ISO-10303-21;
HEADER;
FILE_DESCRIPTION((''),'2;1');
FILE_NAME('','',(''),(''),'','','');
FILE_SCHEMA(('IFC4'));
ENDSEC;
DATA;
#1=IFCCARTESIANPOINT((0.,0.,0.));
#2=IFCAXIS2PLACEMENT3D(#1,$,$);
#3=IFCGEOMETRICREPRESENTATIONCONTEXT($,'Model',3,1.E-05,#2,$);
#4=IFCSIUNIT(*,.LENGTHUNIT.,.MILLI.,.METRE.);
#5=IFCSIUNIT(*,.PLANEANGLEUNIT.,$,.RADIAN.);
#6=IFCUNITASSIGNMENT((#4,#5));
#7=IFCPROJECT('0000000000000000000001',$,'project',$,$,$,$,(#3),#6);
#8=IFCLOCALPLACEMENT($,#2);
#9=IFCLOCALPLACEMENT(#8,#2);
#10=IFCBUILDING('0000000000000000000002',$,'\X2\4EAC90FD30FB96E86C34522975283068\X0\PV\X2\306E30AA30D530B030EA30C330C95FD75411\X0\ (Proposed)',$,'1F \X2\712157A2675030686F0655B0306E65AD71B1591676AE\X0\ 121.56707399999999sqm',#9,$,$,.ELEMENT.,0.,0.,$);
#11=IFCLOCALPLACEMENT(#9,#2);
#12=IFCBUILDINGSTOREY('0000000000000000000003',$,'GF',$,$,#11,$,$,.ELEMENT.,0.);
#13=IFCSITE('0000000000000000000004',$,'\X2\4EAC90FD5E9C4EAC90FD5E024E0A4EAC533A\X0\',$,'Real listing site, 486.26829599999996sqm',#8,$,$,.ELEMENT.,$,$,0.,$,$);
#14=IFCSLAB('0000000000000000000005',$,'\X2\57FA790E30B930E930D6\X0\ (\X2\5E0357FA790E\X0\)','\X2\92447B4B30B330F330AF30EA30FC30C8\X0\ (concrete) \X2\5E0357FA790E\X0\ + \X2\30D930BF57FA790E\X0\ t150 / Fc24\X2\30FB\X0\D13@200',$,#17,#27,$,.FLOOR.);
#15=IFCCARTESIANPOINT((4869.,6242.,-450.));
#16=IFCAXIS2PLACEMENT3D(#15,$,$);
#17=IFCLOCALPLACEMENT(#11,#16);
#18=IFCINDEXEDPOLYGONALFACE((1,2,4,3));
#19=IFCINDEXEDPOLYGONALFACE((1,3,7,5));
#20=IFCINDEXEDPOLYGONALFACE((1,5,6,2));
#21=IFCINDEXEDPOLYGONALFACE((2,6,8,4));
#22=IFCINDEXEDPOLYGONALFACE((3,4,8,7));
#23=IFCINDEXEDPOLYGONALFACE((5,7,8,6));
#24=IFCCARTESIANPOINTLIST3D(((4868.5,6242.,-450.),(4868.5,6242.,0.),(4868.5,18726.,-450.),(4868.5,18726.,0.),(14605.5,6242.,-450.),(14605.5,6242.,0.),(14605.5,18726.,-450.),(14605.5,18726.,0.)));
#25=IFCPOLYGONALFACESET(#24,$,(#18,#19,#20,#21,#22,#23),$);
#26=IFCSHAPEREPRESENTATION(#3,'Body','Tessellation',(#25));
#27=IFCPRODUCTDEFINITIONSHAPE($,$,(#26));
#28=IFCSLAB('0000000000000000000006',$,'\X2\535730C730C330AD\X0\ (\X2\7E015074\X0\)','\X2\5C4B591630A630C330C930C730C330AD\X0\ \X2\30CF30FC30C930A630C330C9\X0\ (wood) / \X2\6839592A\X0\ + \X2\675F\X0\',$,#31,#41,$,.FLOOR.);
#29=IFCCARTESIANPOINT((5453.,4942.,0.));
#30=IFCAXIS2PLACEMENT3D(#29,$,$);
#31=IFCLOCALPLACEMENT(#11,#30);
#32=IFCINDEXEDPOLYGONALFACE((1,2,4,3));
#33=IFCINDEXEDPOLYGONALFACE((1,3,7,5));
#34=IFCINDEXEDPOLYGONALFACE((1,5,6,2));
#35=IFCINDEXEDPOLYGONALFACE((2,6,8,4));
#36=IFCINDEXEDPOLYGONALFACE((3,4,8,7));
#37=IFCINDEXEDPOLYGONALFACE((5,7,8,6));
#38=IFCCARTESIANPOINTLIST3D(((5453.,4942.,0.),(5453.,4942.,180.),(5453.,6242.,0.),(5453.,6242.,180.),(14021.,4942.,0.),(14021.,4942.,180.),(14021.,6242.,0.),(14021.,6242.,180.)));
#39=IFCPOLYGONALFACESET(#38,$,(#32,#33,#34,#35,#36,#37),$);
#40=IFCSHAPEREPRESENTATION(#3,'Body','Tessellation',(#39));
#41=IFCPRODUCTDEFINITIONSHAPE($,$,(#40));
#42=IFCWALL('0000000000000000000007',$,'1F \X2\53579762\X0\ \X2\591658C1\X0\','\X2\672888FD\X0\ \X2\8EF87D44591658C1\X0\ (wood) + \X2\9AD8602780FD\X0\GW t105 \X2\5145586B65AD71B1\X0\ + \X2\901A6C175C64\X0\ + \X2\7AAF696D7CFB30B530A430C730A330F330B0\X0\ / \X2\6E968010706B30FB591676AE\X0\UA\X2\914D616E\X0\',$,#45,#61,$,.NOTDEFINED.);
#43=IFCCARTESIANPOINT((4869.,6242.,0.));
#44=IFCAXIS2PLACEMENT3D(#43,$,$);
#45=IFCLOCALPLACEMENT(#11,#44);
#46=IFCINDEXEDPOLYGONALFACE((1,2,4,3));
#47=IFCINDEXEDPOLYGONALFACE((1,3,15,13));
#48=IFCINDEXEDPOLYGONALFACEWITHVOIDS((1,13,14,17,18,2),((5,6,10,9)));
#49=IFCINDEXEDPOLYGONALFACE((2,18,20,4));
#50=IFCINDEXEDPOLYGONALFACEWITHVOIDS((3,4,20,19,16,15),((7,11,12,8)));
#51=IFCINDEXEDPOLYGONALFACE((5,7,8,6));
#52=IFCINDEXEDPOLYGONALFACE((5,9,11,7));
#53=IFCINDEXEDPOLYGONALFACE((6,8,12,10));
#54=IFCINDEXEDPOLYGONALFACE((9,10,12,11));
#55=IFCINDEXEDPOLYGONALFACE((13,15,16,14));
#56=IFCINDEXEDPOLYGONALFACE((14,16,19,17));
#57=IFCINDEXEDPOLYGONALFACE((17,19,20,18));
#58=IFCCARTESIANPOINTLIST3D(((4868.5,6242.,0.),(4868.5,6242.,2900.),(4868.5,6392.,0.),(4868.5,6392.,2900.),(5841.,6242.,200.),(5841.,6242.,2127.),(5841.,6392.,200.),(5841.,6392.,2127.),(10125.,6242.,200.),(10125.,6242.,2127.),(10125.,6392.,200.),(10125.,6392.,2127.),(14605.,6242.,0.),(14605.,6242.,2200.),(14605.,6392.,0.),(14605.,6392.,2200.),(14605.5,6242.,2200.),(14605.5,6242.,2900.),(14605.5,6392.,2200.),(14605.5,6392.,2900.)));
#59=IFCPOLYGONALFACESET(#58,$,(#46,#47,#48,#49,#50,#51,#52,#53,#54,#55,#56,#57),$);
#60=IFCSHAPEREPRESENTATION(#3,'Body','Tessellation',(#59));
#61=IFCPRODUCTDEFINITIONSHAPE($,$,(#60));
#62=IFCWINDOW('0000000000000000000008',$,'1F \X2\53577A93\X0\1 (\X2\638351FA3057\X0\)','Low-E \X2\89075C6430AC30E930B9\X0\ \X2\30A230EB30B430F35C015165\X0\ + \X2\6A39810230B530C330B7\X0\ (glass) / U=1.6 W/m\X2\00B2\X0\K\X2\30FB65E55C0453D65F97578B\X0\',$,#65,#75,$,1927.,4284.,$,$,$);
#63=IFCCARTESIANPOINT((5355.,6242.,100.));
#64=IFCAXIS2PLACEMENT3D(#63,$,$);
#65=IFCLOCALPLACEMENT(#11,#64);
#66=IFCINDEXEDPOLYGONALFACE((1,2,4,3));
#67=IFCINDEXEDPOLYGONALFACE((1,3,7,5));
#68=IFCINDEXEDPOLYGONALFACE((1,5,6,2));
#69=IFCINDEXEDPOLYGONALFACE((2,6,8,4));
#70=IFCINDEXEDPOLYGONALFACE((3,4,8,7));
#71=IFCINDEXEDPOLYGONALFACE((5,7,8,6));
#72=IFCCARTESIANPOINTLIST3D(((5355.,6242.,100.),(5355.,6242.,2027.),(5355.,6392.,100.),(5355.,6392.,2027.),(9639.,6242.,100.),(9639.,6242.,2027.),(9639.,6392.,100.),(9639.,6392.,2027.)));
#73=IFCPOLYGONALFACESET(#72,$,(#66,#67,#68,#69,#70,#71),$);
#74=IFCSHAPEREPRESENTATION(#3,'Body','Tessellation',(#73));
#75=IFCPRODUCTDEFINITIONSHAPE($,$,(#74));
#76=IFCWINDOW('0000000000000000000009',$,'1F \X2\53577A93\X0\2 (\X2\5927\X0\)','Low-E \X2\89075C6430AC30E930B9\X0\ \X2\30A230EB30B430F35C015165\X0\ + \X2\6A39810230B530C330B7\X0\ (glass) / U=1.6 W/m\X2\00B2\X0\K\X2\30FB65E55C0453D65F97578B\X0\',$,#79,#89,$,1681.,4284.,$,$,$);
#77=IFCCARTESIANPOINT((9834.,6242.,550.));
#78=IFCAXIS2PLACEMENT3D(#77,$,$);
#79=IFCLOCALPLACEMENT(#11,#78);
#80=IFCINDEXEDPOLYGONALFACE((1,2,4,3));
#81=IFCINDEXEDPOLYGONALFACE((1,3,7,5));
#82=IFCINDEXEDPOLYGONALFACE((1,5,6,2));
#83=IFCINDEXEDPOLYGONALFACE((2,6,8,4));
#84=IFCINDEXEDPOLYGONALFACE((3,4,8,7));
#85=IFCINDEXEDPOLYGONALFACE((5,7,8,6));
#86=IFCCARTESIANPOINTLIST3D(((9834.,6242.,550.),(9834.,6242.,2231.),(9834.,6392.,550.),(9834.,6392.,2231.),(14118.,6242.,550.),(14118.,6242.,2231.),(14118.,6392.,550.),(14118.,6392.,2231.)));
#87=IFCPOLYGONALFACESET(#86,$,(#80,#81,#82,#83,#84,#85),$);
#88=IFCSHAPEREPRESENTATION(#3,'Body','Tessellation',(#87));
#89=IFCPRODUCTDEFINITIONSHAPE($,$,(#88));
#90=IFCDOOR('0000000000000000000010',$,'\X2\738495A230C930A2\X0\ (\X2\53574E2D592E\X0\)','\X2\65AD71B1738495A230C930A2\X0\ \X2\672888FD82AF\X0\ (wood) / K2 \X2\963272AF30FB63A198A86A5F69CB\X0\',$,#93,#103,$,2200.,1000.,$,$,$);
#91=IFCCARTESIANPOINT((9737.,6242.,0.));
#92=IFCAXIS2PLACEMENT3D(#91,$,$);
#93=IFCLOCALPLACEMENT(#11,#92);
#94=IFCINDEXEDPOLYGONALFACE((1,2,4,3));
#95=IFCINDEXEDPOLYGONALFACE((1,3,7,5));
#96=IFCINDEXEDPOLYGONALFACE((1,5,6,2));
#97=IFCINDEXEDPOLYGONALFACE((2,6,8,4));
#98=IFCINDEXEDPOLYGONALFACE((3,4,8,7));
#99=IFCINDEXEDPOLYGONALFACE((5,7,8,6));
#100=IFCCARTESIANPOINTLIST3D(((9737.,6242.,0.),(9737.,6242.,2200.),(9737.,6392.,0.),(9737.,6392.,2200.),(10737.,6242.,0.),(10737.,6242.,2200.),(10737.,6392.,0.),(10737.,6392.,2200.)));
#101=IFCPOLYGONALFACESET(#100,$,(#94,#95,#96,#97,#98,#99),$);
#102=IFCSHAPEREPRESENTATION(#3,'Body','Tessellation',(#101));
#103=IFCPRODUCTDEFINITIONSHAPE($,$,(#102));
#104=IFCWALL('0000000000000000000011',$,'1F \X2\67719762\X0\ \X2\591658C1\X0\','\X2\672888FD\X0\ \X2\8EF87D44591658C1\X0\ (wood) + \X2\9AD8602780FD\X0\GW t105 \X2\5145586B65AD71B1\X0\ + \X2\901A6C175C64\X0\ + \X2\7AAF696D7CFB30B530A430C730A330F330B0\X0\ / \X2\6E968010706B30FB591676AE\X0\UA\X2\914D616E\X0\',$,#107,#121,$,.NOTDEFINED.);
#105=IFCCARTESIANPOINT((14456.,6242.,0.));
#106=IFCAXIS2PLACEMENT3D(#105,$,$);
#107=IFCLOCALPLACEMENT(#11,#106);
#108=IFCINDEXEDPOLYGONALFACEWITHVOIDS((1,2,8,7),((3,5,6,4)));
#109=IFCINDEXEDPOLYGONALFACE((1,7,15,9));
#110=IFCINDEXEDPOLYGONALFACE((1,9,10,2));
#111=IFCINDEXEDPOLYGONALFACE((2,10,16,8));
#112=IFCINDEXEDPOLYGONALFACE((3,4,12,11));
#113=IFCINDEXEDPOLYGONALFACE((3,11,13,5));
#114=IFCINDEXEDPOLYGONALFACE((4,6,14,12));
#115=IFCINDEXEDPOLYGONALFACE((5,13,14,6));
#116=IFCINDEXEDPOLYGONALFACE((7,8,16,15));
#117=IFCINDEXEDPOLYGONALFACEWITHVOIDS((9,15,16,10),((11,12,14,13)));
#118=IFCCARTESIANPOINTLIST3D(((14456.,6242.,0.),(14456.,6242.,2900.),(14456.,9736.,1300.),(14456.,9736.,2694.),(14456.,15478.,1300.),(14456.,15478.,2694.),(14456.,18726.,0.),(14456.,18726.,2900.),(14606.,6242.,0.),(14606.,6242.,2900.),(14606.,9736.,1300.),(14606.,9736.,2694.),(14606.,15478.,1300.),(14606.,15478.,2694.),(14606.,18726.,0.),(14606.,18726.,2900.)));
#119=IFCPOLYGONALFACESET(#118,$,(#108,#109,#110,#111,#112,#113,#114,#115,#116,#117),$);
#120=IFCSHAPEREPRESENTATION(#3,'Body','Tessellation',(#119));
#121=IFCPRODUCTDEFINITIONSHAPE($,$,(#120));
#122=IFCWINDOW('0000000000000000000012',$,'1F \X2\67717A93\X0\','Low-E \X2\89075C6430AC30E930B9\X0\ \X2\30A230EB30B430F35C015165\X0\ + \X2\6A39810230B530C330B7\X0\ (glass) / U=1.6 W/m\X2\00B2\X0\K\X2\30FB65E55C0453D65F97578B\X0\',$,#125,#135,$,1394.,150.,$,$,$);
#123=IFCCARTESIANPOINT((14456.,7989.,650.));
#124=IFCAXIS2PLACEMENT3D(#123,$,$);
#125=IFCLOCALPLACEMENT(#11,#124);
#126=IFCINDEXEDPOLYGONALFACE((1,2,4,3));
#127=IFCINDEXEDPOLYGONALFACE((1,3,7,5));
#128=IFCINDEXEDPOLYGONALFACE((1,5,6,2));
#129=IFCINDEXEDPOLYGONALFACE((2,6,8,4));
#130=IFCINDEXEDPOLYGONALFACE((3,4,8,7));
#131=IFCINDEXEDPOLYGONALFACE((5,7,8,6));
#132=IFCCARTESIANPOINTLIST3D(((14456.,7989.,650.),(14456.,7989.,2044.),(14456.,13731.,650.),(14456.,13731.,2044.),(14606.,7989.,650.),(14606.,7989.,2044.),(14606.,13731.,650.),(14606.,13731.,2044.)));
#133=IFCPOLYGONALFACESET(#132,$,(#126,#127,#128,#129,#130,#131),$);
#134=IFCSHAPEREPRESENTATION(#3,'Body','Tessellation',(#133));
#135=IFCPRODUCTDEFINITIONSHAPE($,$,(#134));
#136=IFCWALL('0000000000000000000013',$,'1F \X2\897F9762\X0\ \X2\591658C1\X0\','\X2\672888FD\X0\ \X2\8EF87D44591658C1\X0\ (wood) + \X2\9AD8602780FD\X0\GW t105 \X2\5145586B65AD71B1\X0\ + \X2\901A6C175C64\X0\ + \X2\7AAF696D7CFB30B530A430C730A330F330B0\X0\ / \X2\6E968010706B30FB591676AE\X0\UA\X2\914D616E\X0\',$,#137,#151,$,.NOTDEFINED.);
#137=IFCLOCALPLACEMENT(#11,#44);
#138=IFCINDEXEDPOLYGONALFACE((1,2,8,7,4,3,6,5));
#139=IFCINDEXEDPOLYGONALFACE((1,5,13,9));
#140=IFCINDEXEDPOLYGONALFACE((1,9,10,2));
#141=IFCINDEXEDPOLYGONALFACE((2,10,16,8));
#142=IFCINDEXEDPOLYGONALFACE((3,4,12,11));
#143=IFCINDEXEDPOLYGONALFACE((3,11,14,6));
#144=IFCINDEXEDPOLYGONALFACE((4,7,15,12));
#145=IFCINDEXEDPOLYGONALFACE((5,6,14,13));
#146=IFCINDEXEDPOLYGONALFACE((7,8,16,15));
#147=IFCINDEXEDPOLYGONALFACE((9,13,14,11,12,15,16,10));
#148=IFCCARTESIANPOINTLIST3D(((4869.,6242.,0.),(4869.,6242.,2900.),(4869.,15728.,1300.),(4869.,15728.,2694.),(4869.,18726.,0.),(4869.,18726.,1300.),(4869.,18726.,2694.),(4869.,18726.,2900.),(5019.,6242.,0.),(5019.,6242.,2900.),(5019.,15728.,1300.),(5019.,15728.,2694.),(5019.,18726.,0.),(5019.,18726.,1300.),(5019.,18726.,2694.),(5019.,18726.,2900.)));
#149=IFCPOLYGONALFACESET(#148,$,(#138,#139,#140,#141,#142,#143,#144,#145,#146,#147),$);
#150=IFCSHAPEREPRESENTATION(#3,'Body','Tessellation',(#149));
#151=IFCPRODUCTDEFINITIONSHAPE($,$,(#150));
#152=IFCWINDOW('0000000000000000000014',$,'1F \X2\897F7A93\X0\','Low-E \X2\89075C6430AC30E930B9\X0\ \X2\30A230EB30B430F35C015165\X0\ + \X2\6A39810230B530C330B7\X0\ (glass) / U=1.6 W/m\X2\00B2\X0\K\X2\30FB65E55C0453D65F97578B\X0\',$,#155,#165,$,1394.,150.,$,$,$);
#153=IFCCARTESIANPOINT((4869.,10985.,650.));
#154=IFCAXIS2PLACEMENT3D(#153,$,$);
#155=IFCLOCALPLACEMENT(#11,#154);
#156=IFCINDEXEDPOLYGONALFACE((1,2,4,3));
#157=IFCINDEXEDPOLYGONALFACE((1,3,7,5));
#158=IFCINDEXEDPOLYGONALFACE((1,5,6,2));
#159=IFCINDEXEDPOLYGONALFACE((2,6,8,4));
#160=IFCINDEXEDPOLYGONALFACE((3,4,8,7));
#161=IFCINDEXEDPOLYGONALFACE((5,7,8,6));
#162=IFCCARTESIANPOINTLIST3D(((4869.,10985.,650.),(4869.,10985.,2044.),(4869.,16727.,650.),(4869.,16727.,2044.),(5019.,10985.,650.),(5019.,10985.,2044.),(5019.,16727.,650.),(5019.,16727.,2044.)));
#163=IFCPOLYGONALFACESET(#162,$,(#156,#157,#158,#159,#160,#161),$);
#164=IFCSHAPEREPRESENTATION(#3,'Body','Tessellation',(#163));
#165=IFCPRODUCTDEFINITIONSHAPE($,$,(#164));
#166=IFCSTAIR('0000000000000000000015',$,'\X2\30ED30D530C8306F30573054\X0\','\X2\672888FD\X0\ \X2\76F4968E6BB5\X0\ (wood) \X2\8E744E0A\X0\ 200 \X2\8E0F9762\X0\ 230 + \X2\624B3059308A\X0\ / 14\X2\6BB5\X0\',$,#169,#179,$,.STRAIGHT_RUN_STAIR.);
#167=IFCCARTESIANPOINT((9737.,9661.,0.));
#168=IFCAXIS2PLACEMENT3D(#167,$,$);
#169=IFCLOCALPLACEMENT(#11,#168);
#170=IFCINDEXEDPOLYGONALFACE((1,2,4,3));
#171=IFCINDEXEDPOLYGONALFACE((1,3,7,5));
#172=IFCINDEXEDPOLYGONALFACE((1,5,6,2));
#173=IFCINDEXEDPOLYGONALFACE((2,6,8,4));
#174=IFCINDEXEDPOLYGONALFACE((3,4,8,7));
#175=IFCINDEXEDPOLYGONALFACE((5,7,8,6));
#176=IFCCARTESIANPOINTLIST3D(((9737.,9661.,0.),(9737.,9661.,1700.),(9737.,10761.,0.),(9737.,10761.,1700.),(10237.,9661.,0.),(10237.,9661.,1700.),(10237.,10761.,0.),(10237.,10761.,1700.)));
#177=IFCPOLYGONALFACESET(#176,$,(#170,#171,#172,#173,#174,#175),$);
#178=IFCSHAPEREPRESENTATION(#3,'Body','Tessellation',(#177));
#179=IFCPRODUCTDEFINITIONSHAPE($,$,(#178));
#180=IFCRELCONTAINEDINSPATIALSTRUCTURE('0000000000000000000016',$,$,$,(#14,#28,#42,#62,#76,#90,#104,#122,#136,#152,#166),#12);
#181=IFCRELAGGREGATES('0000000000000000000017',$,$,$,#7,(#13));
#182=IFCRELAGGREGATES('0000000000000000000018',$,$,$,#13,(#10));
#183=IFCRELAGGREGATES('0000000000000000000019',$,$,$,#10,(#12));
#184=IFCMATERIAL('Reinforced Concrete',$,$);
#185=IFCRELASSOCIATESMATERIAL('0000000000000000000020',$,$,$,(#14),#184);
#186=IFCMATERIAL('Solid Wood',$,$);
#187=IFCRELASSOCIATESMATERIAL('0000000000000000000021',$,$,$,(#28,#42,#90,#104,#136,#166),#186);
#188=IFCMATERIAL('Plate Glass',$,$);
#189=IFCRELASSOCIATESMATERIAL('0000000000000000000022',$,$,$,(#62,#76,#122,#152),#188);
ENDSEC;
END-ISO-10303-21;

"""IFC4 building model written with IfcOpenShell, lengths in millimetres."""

from ifc_helpers import new_model, si_unit, frame, frame_2d, origin, place, context, project, spatial, rectangle, extrude, material, element, fill, save


model = new_model("IFC4")

# Units and contexts
model_context = context("Model", 3, precision=1e-05, world=origin())
ifc_project = project(units=[si_unit("LENGTHUNIT", "METRE", prefix="MILLI"), si_unit("PLANEANGLEUNIT", "RADIAN")], contexts=[model_context])

# Site, building, storey
site_placement = place(None, origin())
site = spatial("IfcSite", under=ifc_project, at=site_placement, Name="京都府京都市上京区", ObjectType="Real listing site, 486.26829599999996sqm", CompositionType="ELEMENT", RefElevation=0.0)
building_placement = place(site_placement, origin())
building = spatial("IfcBuilding", under=site, at=building_placement, Name="京都・雨水利用とPVのオフグリッド志向 (Proposed)", ObjectType="1F 無垢材と漆喰の断熱外皮 121.56707399999999sqm", CompositionType="ELEMENT", ElevationOfRefHeight=0.0, ElevationOfTerrain=0.0)
storey_placement = place(building_placement, origin())
storey = spatial("IfcBuildingStorey", under=building, at=storey_placement, Name="GF", CompositionType="ELEMENT", Elevation=0.0)

# Slabs
ifc_material_1 = material(Name="Reinforced Concrete")
slab_1_placement = place(storey_placement, frame((4869.0, 6242.0, -450.0)))
element("IfcSlab", 1, at=slab_1_placement, inside=storey, material=ifc_material_1, Name="基礎スラブ (布基礎)", Description="鉄筋コンクリート (concrete) 布基礎 + ベタ基礎 t150 / Fc24・D13@200", PredefinedType="FLOOR", context=model_context, shape_type="SweptSolid", body=[
    extrude(rectangle(XDim=9737.0, YDim=12484.0, at=frame_2d((4868.0, 6242.0))), frame((4869.0, 6242.0, -450.0)), (0.0, 0.0, 1.0), 450.0),
])
ifc_material_2 = material(Name="Solid Wood")
slab_2_placement = place(storey_placement, frame((5453.0, 4942.0, 0.0)))
element("IfcSlab", 2, at=slab_2_placement, inside=storey, material=ifc_material_2, Name="南デッキ (縁側)", Description="屋外ウッドデッキ ハードウッド (wood) / 根太 + 束", PredefinedType="FLOOR", context=model_context, shape_type="SweptSolid", body=[
    extrude(rectangle(XDim=8568.0, YDim=1300.0, at=frame_2d((4284.0, 650.0))), frame((5453.0, 4942.0, 0.0)), (0.0, 0.0, 1.0), 180.0),
])

# Wall, openings, windows, door
wall_1_placement = place(storey_placement, frame((4869.0, 6242.0, 0.0)))
wall_1 = element("IfcWall", 3, at=wall_1_placement, inside=storey, material=ifc_material_2, Name="1F 南面 外壁", Description="木製 軸組外壁 (wood) + 高性能GW t105 充填断熱 + 通気層 + 窯業系サイディング / 準耐火・外皮UA配慮", PredefinedType="NOTDEFINED", context=model_context, shape_type="SweptSolid", body=[
    extrude(rectangle(XDim=9737.0, YDim=150.0, at=frame_2d((4868.0, 75.0))), frame((4869.0, 6242.0, 0.0)), (0.0, 0.0, 1.0), 2900.0),
])
opening_1_placement = place(storey_placement, frame((5355.0, 6242.0, 100.0)))
opening_1 = element("IfcOpeningElement", 4, at=opening_1_placement, cuts=wall_1, PredefinedType="NOTDEFINED", context=model_context, shape_type="SweptSolid", body=[
    extrude(rectangle(XDim=4284.0, YDim=150.0, at=frame_2d((2142.0, 75.0))), frame((5355.0, 6242.0, 100.0)), (0.0, 0.0, 1.0), 1927.0),
])
opening_2_placement = place(storey_placement, frame((9834.0, 6242.0, 550.0)))
opening_2 = element("IfcOpeningElement", 5, at=opening_2_placement, cuts=wall_1, PredefinedType="NOTDEFINED", context=model_context, shape_type="SweptSolid", body=[
    extrude(rectangle(XDim=4284.0, YDim=150.0, at=frame_2d((2142.0, 75.0))), frame((9834.0, 6242.0, 550.0)), (0.0, 0.0, 1.0), 1681.0),
])
opening_3_placement = place(storey_placement, frame((9737.0, 6242.0, 0.0)))
opening_3 = element("IfcOpeningElement", 6, at=opening_3_placement, cuts=wall_1, PredefinedType="NOTDEFINED", context=model_context, shape_type="SweptSolid", body=[
    extrude(rectangle(XDim=1000.0, YDim=150.0, at=frame_2d((500.0, 75.0))), frame((9737.0, 6242.0, 0.0)), (0.0, 0.0, 1.0), 2200.0),
])
ifc_material_3 = material(Name="Plate Glass")
window_1_placement = place(storey_placement, frame((5355.0, 6242.0, 100.0)))
window_1 = element("IfcWindow", 7, at=window_1_placement, inside=storey, material=ifc_material_3, Name="1F 南窓1 (掃出し)", Description="Low-E 複層ガラス アルゴン封入 + 樹脂サッシ (glass) / U=1.6 W/m²K・日射取得型", OverallHeight=1927.0, OverallWidth=4284.0, context=model_context, shape_type="SweptSolid", body=[
    extrude(rectangle(XDim=4284.0, YDim=150.0, at=frame_2d((2142.0, 75.0))), frame((5355.0, 6242.0, 100.0)), (0.0, 0.0, 1.0), 1927.0),
])
fill(opening_1, window_1)
window_2_placement = place(storey_placement, frame((9834.0, 6242.0, 550.0)))
window_2 = element("IfcWindow", 8, at=window_2_placement, inside=storey, material=ifc_material_3, Name="1F 南窓2 (大)", Description="Low-E 複層ガラス アルゴン封入 + 樹脂サッシ (glass) / U=1.6 W/m²K・日射取得型", OverallHeight=1681.0, OverallWidth=4284.0, context=model_context, shape_type="SweptSolid", body=[
    extrude(rectangle(XDim=4284.0, YDim=150.0, at=frame_2d((2142.0, 75.0))), frame((9834.0, 6242.0, 550.0)), (0.0, 0.0, 1.0), 1681.0),
])
fill(opening_2, window_2)
door_placement = place(storey_placement, frame((9737.0, 6242.0, 0.0)))
door = element("IfcDoor", 9, at=door_placement, inside=storey, material=ifc_material_2, Name="玄関ドア (南中央)", Description="断熱玄関ドア 木製芯 (wood) / K2 防犯・採風機構", OverallHeight=2200.0, OverallWidth=1000.0, context=model_context, shape_type="SweptSolid", body=[
    extrude(rectangle(XDim=1000.0, YDim=150.0, at=frame_2d((500.0, 75.0))), frame((9737.0, 6242.0, 0.0)), (0.0, 0.0, 1.0), 2200.0),
])
fill(opening_3, door)

# Walls, openings, windows
wall_2_placement = place(storey_placement, frame((14456.0, 6242.0, 0.0)))
wall_2 = element("IfcWall", 10, at=wall_2_placement, inside=storey, material=ifc_material_2, Name="1F 東面 外壁", Description="木製 軸組外壁 (wood) + 高性能GW t105 充填断熱 + 通気層 + 窯業系サイディング / 準耐火・外皮UA配慮", PredefinedType="NOTDEFINED", context=model_context, shape_type="SweptSolid", body=[
    extrude(rectangle(XDim=150.0, YDim=12484.0, at=frame_2d((75.0, 6242.0))), frame((14456.0, 6242.0, 0.0)), (0.0, 0.0, 1.0), 2900.0),
])
opening_4_placement = place(storey_placement, frame((14456.0, 7989.0, 650.0)))
opening_4 = element("IfcOpeningElement", 11, at=opening_4_placement, cuts=wall_2, PredefinedType="NOTDEFINED", context=model_context, shape_type="SweptSolid", body=[
    extrude(rectangle(XDim=150.0, YDim=5742.0, at=frame_2d((75.0, 2871.0))), frame((14456.0, 7989.0, 650.0)), (0.0, 0.0, 1.0), 1394.0),
])
window_3_placement = place(storey_placement, frame((14456.0, 7989.0, 650.0)))
window_3 = element("IfcWindow", 12, at=window_3_placement, inside=storey, material=ifc_material_3, Name="1F 東窓", Description="Low-E 複層ガラス アルゴン封入 + 樹脂サッシ (glass) / U=1.6 W/m²K・日射取得型", OverallHeight=1394.0, OverallWidth=150.0, context=model_context, shape_type="SweptSolid", body=[
    extrude(rectangle(XDim=150.0, YDim=5742.0, at=frame_2d((75.0, 2871.0))), frame((14456.0, 7989.0, 650.0)), (0.0, 0.0, 1.0), 1394.0),
])
fill(opening_4, window_3)
wall_3_placement = place(storey_placement, frame((4869.0, 6242.0, 0.0)))
wall_3 = element("IfcWall", 13, at=wall_3_placement, inside=storey, material=ifc_material_2, Name="1F 西面 外壁", Description="木製 軸組外壁 (wood) + 高性能GW t105 充填断熱 + 通気層 + 窯業系サイディング / 準耐火・外皮UA配慮", PredefinedType="NOTDEFINED", context=model_context, shape_type="SweptSolid", body=[
    extrude(rectangle(XDim=150.0, YDim=12484.0, at=frame_2d((75.0, 6242.0))), frame((4869.0, 6242.0, 0.0)), (0.0, 0.0, 1.0), 2900.0),
])
opening_5_placement = place(storey_placement, frame((4869.0, 10985.0, 650.0)))
opening_5 = element("IfcOpeningElement", 14, at=opening_5_placement, cuts=wall_3, PredefinedType="NOTDEFINED", context=model_context, shape_type="SweptSolid", body=[
    extrude(rectangle(XDim=150.0, YDim=5742.0, at=frame_2d((75.0, 2871.0))), frame((4869.0, 10985.0, 650.0)), (0.0, 0.0, 1.0), 1394.0),
])
window_4_placement = place(storey_placement, frame((4869.0, 10985.0, 650.0)))
window_4 = element("IfcWindow", 15, at=window_4_placement, inside=storey, material=ifc_material_3, Name="1F 西窓", Description="Low-E 複層ガラス アルゴン封入 + 樹脂サッシ (glass) / U=1.6 W/m²K・日射取得型", OverallHeight=1394.0, OverallWidth=150.0, context=model_context, shape_type="SweptSolid", body=[
    extrude(rectangle(XDim=150.0, YDim=5742.0, at=frame_2d((75.0, 2871.0))), frame((4869.0, 10985.0, 650.0)), (0.0, 0.0, 1.0), 1394.0),
])
fill(opening_5, window_4)

# Stair
stair_placement = place(storey_placement, frame((9737.0, 9661.0, 0.0)))
element("IfcStair", 16, at=stair_placement, inside=storey, material=ifc_material_2, Name="ロフトはしご", Description="木製 直階段 (wood) 蹴上 200 踏面 230 + 手すり / 14段", PredefinedType="STRAIGHT_RUN_STAIR", context=model_context, shape_type="SweptSolid", body=[
    extrude(rectangle(XDim=500.0, YDim=1100.0, at=frame_2d((250.0, 550.0))), frame((9737.0, 9661.0, 0.0)), (0.0, 0.0, 1.0), 1700.0),
])

save(model, "model.ifc")
